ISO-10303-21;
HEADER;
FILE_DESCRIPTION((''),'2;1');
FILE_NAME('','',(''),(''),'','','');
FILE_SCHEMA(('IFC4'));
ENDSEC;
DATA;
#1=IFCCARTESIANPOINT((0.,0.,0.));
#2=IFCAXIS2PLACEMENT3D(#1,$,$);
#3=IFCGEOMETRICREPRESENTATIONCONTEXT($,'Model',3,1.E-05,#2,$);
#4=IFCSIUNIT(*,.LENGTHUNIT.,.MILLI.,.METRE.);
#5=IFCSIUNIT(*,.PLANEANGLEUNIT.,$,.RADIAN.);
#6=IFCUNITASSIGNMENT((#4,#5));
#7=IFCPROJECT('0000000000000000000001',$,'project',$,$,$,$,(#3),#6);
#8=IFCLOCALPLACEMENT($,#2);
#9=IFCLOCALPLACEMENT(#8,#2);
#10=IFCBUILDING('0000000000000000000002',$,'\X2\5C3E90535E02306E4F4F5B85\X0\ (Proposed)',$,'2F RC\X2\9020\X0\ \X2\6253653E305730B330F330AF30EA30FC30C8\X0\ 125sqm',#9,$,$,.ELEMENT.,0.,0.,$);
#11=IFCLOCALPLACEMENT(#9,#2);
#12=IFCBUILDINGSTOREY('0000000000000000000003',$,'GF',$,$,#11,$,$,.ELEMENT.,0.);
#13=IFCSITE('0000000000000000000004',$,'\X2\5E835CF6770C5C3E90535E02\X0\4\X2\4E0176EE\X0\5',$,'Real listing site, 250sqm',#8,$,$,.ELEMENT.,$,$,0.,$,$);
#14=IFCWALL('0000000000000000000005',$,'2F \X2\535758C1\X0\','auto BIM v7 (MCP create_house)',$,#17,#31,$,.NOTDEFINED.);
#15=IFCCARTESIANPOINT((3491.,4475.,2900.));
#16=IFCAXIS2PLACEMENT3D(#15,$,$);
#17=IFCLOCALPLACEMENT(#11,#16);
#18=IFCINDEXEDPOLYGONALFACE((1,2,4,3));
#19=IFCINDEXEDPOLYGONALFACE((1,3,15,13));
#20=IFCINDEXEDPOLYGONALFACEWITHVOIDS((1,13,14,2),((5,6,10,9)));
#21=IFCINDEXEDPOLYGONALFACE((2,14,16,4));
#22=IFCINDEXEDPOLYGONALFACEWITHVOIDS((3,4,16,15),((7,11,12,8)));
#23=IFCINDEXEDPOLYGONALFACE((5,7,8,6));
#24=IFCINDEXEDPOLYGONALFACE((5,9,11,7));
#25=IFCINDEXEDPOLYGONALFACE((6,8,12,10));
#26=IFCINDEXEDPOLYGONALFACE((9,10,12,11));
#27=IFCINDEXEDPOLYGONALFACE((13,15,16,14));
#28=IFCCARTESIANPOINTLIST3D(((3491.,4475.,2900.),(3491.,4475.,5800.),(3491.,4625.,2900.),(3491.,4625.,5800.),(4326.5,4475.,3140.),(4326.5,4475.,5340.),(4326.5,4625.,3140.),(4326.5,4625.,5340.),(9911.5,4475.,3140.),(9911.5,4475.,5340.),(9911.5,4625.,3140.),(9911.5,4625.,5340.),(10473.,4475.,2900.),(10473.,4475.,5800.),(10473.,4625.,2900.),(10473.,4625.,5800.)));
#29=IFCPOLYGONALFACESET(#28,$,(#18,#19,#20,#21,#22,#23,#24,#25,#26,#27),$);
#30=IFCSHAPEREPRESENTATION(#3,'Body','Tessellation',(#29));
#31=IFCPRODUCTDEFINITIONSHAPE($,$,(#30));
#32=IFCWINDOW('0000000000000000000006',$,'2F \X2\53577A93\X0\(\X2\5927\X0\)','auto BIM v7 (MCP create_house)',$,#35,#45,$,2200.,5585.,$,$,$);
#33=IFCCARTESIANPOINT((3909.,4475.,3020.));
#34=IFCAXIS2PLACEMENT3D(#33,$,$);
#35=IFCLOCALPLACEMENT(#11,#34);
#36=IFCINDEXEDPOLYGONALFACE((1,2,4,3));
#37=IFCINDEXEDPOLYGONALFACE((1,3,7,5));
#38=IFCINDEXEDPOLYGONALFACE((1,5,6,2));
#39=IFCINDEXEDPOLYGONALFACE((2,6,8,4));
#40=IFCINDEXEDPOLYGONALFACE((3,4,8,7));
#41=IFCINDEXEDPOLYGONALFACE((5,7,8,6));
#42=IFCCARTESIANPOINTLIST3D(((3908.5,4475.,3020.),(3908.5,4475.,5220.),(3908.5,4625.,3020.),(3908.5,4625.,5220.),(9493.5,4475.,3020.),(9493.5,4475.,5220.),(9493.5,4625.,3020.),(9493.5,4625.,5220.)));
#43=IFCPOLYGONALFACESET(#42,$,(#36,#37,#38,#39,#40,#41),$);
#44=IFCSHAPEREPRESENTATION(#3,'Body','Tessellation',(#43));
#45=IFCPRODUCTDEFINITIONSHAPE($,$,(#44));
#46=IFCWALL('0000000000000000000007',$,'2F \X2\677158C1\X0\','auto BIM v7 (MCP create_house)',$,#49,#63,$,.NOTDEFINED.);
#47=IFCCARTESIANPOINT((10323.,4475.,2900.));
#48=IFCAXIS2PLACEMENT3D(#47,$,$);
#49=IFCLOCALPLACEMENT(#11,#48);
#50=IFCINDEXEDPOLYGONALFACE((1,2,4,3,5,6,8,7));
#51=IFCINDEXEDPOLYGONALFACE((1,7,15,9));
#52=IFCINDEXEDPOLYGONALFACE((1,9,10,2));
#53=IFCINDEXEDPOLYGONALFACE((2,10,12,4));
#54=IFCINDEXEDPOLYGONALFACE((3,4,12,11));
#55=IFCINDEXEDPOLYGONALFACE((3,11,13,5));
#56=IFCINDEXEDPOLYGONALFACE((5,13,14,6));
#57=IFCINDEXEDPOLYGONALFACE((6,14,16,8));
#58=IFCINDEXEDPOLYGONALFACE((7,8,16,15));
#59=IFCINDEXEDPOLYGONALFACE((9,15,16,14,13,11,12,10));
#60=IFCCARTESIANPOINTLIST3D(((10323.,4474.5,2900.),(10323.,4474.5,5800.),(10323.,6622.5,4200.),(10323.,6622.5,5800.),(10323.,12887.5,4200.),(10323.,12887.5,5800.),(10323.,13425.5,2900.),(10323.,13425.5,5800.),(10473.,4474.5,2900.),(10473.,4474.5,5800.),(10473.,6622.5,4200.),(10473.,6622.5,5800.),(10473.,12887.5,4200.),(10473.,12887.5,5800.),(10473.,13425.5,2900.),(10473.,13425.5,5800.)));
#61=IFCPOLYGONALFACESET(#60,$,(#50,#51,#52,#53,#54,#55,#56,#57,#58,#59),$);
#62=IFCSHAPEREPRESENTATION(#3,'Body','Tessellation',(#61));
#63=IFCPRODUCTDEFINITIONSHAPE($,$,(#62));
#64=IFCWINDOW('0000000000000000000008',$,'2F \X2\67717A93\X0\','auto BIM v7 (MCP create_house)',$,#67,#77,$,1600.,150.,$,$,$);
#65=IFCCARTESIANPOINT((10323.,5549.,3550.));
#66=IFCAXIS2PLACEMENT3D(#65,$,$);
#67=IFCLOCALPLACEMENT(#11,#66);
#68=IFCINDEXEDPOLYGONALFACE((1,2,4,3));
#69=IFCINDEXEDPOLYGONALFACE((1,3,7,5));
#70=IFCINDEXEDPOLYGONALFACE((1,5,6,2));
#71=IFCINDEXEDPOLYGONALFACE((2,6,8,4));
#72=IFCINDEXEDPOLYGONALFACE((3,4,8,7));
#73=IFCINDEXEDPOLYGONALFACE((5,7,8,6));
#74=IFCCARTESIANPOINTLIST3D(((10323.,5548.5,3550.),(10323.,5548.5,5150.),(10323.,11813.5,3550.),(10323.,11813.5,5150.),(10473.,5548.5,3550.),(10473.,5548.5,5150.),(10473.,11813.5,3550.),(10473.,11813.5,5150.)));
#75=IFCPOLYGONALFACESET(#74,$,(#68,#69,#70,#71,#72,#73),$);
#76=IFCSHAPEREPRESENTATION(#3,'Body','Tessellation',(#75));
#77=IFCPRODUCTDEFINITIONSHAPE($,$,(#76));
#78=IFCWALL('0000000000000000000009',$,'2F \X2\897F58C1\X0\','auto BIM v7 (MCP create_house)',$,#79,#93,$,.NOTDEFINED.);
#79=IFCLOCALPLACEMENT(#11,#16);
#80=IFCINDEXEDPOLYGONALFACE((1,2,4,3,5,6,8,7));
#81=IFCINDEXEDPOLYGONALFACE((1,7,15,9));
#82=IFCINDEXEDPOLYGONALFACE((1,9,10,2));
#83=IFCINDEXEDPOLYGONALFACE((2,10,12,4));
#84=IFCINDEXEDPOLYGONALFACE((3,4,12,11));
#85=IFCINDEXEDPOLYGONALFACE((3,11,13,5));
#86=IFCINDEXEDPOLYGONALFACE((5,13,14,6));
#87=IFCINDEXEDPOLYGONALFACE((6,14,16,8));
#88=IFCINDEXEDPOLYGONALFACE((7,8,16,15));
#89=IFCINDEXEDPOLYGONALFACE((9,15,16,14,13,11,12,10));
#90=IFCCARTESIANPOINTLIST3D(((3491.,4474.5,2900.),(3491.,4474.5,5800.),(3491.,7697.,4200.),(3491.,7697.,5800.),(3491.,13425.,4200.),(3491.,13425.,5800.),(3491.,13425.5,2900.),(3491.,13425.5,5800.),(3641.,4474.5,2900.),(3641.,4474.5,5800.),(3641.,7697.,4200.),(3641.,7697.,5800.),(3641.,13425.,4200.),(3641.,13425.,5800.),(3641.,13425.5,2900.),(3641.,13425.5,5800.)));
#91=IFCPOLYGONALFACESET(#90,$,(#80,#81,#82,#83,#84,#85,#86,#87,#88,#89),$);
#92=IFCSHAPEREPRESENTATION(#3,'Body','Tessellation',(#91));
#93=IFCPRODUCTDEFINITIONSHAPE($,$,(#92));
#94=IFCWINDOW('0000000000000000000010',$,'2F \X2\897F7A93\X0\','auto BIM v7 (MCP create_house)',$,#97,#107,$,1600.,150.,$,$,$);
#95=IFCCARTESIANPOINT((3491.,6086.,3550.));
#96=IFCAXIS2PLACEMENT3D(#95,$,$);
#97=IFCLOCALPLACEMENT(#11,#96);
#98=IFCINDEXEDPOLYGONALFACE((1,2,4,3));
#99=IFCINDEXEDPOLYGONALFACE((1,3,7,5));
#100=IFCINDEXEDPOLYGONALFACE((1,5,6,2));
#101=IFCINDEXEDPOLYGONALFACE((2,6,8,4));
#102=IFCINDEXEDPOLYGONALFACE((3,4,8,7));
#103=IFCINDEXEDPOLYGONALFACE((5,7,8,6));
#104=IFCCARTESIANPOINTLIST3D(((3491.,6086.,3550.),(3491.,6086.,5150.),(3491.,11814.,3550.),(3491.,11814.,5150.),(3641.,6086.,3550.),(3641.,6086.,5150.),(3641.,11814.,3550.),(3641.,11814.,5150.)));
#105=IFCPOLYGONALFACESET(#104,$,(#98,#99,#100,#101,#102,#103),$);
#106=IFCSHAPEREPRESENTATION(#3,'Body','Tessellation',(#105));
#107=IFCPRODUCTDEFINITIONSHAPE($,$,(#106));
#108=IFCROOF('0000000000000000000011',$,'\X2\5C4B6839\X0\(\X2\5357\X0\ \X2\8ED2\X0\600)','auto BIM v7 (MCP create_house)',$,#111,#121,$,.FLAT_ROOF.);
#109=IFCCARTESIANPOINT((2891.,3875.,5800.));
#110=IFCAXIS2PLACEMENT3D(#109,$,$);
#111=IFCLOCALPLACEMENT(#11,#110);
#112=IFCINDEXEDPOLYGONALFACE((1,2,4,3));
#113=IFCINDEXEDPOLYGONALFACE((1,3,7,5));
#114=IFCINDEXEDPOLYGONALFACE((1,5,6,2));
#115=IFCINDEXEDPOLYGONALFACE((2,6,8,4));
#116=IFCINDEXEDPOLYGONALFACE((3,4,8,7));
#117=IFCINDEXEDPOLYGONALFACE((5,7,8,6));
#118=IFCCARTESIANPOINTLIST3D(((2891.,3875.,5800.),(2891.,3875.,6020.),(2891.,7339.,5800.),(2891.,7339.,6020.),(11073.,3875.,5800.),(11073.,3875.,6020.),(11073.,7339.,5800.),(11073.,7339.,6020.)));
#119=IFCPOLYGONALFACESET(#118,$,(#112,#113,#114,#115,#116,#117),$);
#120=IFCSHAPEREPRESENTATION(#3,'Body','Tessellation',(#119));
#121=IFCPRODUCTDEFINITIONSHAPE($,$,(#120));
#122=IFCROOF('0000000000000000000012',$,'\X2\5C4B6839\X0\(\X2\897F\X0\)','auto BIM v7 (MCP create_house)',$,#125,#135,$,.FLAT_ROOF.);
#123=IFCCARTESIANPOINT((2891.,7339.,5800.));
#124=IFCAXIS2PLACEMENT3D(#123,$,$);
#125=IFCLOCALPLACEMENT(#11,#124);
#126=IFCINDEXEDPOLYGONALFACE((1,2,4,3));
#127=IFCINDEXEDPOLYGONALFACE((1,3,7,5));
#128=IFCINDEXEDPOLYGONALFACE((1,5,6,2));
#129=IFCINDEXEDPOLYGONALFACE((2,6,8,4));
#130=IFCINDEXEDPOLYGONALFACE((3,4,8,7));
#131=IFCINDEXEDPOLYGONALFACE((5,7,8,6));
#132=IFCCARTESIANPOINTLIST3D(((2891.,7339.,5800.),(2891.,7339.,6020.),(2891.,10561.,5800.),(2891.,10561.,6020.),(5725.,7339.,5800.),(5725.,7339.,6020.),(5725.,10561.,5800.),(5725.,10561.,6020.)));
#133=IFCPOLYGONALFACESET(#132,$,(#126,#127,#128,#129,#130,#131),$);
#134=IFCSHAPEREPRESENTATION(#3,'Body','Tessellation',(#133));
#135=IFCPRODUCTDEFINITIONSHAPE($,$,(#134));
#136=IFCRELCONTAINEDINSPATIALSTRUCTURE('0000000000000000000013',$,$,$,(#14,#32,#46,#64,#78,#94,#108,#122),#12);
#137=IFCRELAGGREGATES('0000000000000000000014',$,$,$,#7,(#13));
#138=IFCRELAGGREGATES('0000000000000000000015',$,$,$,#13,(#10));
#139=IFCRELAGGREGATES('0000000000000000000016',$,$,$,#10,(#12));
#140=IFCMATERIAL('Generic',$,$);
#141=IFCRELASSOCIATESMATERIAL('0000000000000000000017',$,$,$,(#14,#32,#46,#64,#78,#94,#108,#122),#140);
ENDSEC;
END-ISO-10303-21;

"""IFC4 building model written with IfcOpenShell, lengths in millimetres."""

from ifc_helpers import new_model, si_unit, frame, frame_2d, origin, place, context, project, spatial, rectangle, extrude, material, element, fill, save


model = new_model("IFC4")

# Units and contexts
model_context = context("Model", 3, precision=1e-05, world=origin())
ifc_project = project(units=[si_unit("LENGTHUNIT", "METRE", prefix="MILLI"), si_unit("PLANEANGLEUNIT", "RADIAN")], contexts=[model_context])

# Site, building, storey
site_placement = place(None, origin())
site = spatial("IfcSite", under=ifc_project, at=site_placement, Name="広島県尾道市4丁目5", ObjectType="Real listing site, 250sqm", CompositionType="ELEMENT", RefElevation=0.0)
building_placement = place(site_placement, origin())
building = spatial("IfcBuilding", under=site, at=building_placement, Name="尾道市の住宅 (Proposed)", ObjectType="2F RC造 打放しコンクリート 125sqm", CompositionType="ELEMENT", ElevationOfRefHeight=0.0, ElevationOfTerrain=0.0)
storey_placement = place(building_placement, origin())
storey = spatial("IfcBuildingStorey", under=building, at=storey_placement, Name="GF", CompositionType="ELEMENT", Elevation=0.0)

# Shared definitions
ifc_material = material(Name="Generic")

# Walls, openings, windows
wall_1_placement = place(storey_placement, frame((3491.0, 4475.0, 2900.0)))
wall_1 = element("IfcWall", 1, at=wall_1_placement, inside=storey, material=ifc_material, Name="2F 南壁", Description="auto BIM v7 (MCP create_house)", PredefinedType="NOTDEFINED", context=model_context, shape_type="SweptSolid", body=[
    extrude(rectangle(XDim=6982.0, YDim=150.0, at=frame_2d((3491.0, 75.0))), frame((3491.0, 4475.0, 2900.0)), (0.0, 0.0, 1.0), 2900.0),
])
opening_1_placement = place(storey_placement, frame((3909.0, 4475.0, 3020.0)))
opening_1 = element("IfcOpeningElement", 2, at=opening_1_placement, cuts=wall_1, PredefinedType="NOTDEFINED", context=model_context, shape_type="SweptSolid", body=[
    extrude(rectangle(XDim=5585.0, YDim=150.0, at=frame_2d((2792.0, 75.0))), frame((3909.0, 4475.0, 3020.0)), (0.0, 0.0, 1.0), 2200.0),
])
window_1_placement = place(storey_placement, frame((3909.0, 4475.0, 3020.0)))
window_1 = element("IfcWindow", 3, at=window_1_placement, inside=storey, material=ifc_material, Name="2F 南窓(大)", Description="auto BIM v7 (MCP create_house)", OverallHeight=2200.0, OverallWidth=5585.0, context=model_context, shape_type="SweptSolid", body=[
    extrude(rectangle(XDim=5585.0, YDim=150.0, at=frame_2d((2792.0, 75.0))), frame((3909.0, 4475.0, 3020.0)), (0.0, 0.0, 1.0), 2200.0),
])
fill(opening_1, window_1)
wall_2_placement = place(storey_placement, frame((10323.0, 4475.0, 2900.0)))
wall_2 = element("IfcWall", 4, at=wall_2_placement, inside=storey, material=ifc_material, Name="2F 東壁", Description="auto BIM v7 (MCP create_house)", PredefinedType="NOTDEFINED", context=model_context, shape_type="SweptSolid", body=[
    extrude(rectangle(XDim=150.0, YDim=8951.0, at=frame_2d((75.0, 4475.0))), frame((10323.0, 4475.0, 2900.0)), (0.0, 0.0, 1.0), 2900.0),
])
opening_2_placement = place(storey_placement, frame((10323.0, 5549.0, 3550.0)))
opening_2 = element("IfcOpeningElement", 5, at=opening_2_placement, cuts=wall_2, PredefinedType="NOTDEFINED", context=model_context, shape_type="SweptSolid", body=[
    extrude(rectangle(XDim=150.0, YDim=6265.0, at=frame_2d((75.0, 3132.0))), frame((10323.0, 5549.0, 3550.0)), (0.0, 0.0, 1.0), 1600.0),
])
window_2_placement = place(storey_placement, frame((10323.0, 5549.0, 3550.0)))
window_2 = element("IfcWindow", 6, at=window_2_placement, inside=storey, material=ifc_material, Name="2F 東窓", Description="auto BIM v7 (MCP create_house)", OverallHeight=1600.0, OverallWidth=150.0, context=model_context, shape_type="SweptSolid", body=[
    extrude(rectangle(XDim=150.0, YDim=6265.0, at=frame_2d((75.0, 3132.0))), frame((10323.0, 5549.0, 3550.0)), (0.0, 0.0, 1.0), 1600.0),
])
fill(opening_2, window_2)
wall_3_placement = place(storey_placement, frame((3491.0, 4475.0, 2900.0)))
wall_3 = element("IfcWall", 7, at=wall_3_placement, inside=storey, material=ifc_material, Name="2F 西壁", Description="auto BIM v7 (MCP create_house)", PredefinedType="NOTDEFINED", context=model_context, shape_type="SweptSolid", body=[
    extrude(rectangle(XDim=150.0, YDim=8951.0, at=frame_2d((75.0, 4475.0))), frame((3491.0, 4475.0, 2900.0)), (0.0, 0.0, 1.0), 2900.0),
])
opening_3_placement = place(storey_placement, frame((3491.0, 6086.0, 3550.0)))
opening_3 = element("IfcOpeningElement", 8, at=opening_3_placement, cuts=wall_3, PredefinedType="NOTDEFINED", context=model_context, shape_type="SweptSolid", body=[
    extrude(rectangle(XDim=150.0, YDim=5728.0, at=frame_2d((75.0, 2864.0))), frame((3491.0, 6086.0, 3550.0)), (0.0, 0.0, 1.0), 1600.0),
])
window_3_placement = place(storey_placement, frame((3491.0, 6086.0, 3550.0)))
window_3 = element("IfcWindow", 9, at=window_3_placement, inside=storey, material=ifc_material, Name="2F 西窓", Description="auto BIM v7 (MCP create_house)", OverallHeight=1600.0, OverallWidth=150.0, context=model_context, shape_type="SweptSolid", body=[
    extrude(rectangle(XDim=150.0, YDim=5728.0, at=frame_2d((75.0, 2864.0))), frame((3491.0, 6086.0, 3550.0)), (0.0, 0.0, 1.0), 1600.0),
])
fill(opening_3, window_3)

# Roofs
roof_1_placement = place(storey_placement, frame((2891.0, 3875.0, 5800.0)))
element("IfcRoof", 10, at=roof_1_placement, inside=storey, material=ifc_material, Name="屋根(南 軒600)", Description="auto BIM v7 (MCP create_house)", PredefinedType="FLAT_ROOF", context=model_context, shape_type="SweptSolid", body=[
    extrude(rectangle(XDim=8182.0, YDim=3464.0, at=frame_2d((4091.0, 1732.0))), frame((2891.0, 3875.0, 5800.0)), (0.0, 0.0, 1.0), 220.0),
])
roof_2_placement = place(storey_placement, frame((2891.0, 7339.0, 5800.0)))
element("IfcRoof", 11, at=roof_2_placement, inside=storey, material=ifc_material, Name="屋根(西)", Description="auto BIM v7 (MCP create_house)", PredefinedType="FLAT_ROOF", context=model_context, shape_type="SweptSolid", body=[
    extrude(rectangle(XDim=2834.0, YDim=3222.0, at=frame_2d((1417.0, 1611.0))), frame((2891.0, 7339.0, 5800.0)), (0.0, 0.0, 1.0), 220.0),
])

save(model, "model.ifc")
